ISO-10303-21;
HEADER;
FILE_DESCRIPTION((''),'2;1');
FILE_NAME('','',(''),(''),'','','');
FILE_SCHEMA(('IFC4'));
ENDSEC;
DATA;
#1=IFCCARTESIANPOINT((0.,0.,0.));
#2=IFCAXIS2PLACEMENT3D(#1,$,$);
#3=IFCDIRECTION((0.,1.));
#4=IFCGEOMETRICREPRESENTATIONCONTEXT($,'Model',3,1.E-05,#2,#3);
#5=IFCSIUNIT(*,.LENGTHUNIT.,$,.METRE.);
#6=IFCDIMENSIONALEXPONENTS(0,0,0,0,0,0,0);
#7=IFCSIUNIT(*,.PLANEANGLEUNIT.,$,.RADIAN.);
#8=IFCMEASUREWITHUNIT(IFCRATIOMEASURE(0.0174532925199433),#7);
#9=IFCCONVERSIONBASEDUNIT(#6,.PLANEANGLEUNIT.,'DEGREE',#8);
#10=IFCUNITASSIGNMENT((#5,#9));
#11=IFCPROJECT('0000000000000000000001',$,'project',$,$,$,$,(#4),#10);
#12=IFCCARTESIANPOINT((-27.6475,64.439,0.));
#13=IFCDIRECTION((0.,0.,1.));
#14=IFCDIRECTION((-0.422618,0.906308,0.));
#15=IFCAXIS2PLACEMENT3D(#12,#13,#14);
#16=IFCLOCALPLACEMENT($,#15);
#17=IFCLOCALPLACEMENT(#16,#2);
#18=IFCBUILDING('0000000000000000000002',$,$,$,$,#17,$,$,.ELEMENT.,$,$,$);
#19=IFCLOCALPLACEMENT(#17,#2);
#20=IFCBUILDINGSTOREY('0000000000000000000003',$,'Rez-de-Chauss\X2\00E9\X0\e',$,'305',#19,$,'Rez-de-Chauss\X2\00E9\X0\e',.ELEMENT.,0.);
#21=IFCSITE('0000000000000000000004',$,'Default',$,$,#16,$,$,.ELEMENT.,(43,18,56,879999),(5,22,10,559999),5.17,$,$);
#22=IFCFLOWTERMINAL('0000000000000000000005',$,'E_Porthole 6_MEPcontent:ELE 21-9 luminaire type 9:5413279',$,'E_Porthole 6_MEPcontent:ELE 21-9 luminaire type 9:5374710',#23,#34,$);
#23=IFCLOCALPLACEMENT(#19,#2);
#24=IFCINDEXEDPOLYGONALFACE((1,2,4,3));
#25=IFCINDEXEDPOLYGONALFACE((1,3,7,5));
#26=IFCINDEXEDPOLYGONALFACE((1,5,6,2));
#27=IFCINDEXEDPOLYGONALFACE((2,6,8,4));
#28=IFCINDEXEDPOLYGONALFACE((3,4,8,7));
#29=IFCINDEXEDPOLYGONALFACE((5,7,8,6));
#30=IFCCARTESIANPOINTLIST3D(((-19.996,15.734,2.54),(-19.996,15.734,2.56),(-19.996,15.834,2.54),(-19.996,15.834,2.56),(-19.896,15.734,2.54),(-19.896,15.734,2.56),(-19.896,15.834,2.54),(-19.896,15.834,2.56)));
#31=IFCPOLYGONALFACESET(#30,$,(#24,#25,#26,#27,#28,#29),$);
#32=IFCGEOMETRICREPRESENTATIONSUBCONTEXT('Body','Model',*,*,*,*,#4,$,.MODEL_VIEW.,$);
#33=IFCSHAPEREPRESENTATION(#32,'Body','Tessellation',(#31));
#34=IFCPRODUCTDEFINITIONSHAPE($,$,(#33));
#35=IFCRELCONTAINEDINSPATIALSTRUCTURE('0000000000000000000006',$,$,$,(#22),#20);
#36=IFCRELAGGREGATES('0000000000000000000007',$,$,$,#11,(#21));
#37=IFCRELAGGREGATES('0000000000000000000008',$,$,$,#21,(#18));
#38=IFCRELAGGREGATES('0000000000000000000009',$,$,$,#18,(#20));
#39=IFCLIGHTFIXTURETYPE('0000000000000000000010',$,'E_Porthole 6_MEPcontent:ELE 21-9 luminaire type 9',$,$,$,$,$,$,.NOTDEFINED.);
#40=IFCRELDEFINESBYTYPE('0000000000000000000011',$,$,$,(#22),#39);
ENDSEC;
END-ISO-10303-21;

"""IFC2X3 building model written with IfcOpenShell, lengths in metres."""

from ifc_helpers import new_model, entity, si_unit, converted_unit, direction, frame, origin, origin_2d_with_axis, place, context, subcontext, project, spatial, rectangle, extrude, source, transform, mapped, type_object, type_shapes, element, save


model = new_model("IFC2X3")

# Units and contexts
model_context = context("Model", 3, precision=1e-05, world=origin(), true_north=direction((0.0, 1.0)))
body_context = subcontext(model_context, "Body", "Model", "MODEL_VIEW")
ifc_project = project(units=[si_unit("LENGTHUNIT", "METRE"), converted_unit("PLANEANGLEUNIT", "DEGREE", entity("IfcRatioMeasure", 0.0174532925199433), si_unit("PLANEANGLEUNIT", "RADIAN"), dimensions=[0, 0, 0, 0, 0, 0, 0])], contexts=[model_context])

# Site, building, storey
site_placement = place(None, frame((-27.6475, 64.439, 0.0), z_axis=(0.0, 0.0, 1.0), x_axis=(-0.422618, 0.906308, 0.0)))
site = spatial("IfcSite", under=ifc_project, at=site_placement, Name="Default", CompositionType="ELEMENT", RefLatitude=(43, 18, 56, 879999), RefLongitude=(5, 22, 10, 559999), RefElevation=5.17)
building_placement = place(site_placement, origin())
building = spatial("IfcBuilding", under=site, at=building_placement, CompositionType="ELEMENT")
storey_placement = place(building_placement, origin())
storey = spatial("IfcBuildingStorey", under=building, at=storey_placement, Name="Rez-de-Chaussée", ObjectType="305", LongName="Rez-de-Chaussée", CompositionType="ELEMENT", Elevation=0.0)

# Flow terminal
light_fixture_type_1 = type_object("IfcLightFixtureType", Name="E_Porthole 6_MEPcontent:ELE 21-9 luminaire type 9", PredefinedType="NOTDEFINED")
shared_shape_1 = source(origin(), body_context, "Body", "SweptSolid", [
    extrude(rectangle(XDim=0.1, YDim=0.1, at=origin_2d_with_axis()), frame((0.0, 0.0, 0.0), z_axis=(0.0, 0.0, 1.0), x_axis=(0.0, -1.0, 0.0)), (0.0, 0.0, 1.0), 0.02),
])
type_shapes(light_fixture_type_1, [shared_shape_1])
for number, where, z_axis, x_axis, name in (
    (1, (-19.946, 15.784, 2.54), (0.0, 0.0, 1.0), (0.0, -1.0, 0.0), "E_Porthole 6_MEPcontent:ELE 21-9 luminaire type 9:5413279"),
):
    element("IfcFlowTerminal", number, at=place(storey_placement, frame(where, z_axis=z_axis, x_axis=x_axis)), inside=storey, type_object=light_fixture_type_1, Name=name, ObjectType="E_Porthole 6_MEPcontent:ELE 21-9 luminaire type 9:5374710", context=body_context, shape_type="MappedRepresentation", body=[
        mapped(shared_shape_1, transform((0.0, 0.0, 0.0), scale=1.0)),
    ])

save(model, "model.ifc")
